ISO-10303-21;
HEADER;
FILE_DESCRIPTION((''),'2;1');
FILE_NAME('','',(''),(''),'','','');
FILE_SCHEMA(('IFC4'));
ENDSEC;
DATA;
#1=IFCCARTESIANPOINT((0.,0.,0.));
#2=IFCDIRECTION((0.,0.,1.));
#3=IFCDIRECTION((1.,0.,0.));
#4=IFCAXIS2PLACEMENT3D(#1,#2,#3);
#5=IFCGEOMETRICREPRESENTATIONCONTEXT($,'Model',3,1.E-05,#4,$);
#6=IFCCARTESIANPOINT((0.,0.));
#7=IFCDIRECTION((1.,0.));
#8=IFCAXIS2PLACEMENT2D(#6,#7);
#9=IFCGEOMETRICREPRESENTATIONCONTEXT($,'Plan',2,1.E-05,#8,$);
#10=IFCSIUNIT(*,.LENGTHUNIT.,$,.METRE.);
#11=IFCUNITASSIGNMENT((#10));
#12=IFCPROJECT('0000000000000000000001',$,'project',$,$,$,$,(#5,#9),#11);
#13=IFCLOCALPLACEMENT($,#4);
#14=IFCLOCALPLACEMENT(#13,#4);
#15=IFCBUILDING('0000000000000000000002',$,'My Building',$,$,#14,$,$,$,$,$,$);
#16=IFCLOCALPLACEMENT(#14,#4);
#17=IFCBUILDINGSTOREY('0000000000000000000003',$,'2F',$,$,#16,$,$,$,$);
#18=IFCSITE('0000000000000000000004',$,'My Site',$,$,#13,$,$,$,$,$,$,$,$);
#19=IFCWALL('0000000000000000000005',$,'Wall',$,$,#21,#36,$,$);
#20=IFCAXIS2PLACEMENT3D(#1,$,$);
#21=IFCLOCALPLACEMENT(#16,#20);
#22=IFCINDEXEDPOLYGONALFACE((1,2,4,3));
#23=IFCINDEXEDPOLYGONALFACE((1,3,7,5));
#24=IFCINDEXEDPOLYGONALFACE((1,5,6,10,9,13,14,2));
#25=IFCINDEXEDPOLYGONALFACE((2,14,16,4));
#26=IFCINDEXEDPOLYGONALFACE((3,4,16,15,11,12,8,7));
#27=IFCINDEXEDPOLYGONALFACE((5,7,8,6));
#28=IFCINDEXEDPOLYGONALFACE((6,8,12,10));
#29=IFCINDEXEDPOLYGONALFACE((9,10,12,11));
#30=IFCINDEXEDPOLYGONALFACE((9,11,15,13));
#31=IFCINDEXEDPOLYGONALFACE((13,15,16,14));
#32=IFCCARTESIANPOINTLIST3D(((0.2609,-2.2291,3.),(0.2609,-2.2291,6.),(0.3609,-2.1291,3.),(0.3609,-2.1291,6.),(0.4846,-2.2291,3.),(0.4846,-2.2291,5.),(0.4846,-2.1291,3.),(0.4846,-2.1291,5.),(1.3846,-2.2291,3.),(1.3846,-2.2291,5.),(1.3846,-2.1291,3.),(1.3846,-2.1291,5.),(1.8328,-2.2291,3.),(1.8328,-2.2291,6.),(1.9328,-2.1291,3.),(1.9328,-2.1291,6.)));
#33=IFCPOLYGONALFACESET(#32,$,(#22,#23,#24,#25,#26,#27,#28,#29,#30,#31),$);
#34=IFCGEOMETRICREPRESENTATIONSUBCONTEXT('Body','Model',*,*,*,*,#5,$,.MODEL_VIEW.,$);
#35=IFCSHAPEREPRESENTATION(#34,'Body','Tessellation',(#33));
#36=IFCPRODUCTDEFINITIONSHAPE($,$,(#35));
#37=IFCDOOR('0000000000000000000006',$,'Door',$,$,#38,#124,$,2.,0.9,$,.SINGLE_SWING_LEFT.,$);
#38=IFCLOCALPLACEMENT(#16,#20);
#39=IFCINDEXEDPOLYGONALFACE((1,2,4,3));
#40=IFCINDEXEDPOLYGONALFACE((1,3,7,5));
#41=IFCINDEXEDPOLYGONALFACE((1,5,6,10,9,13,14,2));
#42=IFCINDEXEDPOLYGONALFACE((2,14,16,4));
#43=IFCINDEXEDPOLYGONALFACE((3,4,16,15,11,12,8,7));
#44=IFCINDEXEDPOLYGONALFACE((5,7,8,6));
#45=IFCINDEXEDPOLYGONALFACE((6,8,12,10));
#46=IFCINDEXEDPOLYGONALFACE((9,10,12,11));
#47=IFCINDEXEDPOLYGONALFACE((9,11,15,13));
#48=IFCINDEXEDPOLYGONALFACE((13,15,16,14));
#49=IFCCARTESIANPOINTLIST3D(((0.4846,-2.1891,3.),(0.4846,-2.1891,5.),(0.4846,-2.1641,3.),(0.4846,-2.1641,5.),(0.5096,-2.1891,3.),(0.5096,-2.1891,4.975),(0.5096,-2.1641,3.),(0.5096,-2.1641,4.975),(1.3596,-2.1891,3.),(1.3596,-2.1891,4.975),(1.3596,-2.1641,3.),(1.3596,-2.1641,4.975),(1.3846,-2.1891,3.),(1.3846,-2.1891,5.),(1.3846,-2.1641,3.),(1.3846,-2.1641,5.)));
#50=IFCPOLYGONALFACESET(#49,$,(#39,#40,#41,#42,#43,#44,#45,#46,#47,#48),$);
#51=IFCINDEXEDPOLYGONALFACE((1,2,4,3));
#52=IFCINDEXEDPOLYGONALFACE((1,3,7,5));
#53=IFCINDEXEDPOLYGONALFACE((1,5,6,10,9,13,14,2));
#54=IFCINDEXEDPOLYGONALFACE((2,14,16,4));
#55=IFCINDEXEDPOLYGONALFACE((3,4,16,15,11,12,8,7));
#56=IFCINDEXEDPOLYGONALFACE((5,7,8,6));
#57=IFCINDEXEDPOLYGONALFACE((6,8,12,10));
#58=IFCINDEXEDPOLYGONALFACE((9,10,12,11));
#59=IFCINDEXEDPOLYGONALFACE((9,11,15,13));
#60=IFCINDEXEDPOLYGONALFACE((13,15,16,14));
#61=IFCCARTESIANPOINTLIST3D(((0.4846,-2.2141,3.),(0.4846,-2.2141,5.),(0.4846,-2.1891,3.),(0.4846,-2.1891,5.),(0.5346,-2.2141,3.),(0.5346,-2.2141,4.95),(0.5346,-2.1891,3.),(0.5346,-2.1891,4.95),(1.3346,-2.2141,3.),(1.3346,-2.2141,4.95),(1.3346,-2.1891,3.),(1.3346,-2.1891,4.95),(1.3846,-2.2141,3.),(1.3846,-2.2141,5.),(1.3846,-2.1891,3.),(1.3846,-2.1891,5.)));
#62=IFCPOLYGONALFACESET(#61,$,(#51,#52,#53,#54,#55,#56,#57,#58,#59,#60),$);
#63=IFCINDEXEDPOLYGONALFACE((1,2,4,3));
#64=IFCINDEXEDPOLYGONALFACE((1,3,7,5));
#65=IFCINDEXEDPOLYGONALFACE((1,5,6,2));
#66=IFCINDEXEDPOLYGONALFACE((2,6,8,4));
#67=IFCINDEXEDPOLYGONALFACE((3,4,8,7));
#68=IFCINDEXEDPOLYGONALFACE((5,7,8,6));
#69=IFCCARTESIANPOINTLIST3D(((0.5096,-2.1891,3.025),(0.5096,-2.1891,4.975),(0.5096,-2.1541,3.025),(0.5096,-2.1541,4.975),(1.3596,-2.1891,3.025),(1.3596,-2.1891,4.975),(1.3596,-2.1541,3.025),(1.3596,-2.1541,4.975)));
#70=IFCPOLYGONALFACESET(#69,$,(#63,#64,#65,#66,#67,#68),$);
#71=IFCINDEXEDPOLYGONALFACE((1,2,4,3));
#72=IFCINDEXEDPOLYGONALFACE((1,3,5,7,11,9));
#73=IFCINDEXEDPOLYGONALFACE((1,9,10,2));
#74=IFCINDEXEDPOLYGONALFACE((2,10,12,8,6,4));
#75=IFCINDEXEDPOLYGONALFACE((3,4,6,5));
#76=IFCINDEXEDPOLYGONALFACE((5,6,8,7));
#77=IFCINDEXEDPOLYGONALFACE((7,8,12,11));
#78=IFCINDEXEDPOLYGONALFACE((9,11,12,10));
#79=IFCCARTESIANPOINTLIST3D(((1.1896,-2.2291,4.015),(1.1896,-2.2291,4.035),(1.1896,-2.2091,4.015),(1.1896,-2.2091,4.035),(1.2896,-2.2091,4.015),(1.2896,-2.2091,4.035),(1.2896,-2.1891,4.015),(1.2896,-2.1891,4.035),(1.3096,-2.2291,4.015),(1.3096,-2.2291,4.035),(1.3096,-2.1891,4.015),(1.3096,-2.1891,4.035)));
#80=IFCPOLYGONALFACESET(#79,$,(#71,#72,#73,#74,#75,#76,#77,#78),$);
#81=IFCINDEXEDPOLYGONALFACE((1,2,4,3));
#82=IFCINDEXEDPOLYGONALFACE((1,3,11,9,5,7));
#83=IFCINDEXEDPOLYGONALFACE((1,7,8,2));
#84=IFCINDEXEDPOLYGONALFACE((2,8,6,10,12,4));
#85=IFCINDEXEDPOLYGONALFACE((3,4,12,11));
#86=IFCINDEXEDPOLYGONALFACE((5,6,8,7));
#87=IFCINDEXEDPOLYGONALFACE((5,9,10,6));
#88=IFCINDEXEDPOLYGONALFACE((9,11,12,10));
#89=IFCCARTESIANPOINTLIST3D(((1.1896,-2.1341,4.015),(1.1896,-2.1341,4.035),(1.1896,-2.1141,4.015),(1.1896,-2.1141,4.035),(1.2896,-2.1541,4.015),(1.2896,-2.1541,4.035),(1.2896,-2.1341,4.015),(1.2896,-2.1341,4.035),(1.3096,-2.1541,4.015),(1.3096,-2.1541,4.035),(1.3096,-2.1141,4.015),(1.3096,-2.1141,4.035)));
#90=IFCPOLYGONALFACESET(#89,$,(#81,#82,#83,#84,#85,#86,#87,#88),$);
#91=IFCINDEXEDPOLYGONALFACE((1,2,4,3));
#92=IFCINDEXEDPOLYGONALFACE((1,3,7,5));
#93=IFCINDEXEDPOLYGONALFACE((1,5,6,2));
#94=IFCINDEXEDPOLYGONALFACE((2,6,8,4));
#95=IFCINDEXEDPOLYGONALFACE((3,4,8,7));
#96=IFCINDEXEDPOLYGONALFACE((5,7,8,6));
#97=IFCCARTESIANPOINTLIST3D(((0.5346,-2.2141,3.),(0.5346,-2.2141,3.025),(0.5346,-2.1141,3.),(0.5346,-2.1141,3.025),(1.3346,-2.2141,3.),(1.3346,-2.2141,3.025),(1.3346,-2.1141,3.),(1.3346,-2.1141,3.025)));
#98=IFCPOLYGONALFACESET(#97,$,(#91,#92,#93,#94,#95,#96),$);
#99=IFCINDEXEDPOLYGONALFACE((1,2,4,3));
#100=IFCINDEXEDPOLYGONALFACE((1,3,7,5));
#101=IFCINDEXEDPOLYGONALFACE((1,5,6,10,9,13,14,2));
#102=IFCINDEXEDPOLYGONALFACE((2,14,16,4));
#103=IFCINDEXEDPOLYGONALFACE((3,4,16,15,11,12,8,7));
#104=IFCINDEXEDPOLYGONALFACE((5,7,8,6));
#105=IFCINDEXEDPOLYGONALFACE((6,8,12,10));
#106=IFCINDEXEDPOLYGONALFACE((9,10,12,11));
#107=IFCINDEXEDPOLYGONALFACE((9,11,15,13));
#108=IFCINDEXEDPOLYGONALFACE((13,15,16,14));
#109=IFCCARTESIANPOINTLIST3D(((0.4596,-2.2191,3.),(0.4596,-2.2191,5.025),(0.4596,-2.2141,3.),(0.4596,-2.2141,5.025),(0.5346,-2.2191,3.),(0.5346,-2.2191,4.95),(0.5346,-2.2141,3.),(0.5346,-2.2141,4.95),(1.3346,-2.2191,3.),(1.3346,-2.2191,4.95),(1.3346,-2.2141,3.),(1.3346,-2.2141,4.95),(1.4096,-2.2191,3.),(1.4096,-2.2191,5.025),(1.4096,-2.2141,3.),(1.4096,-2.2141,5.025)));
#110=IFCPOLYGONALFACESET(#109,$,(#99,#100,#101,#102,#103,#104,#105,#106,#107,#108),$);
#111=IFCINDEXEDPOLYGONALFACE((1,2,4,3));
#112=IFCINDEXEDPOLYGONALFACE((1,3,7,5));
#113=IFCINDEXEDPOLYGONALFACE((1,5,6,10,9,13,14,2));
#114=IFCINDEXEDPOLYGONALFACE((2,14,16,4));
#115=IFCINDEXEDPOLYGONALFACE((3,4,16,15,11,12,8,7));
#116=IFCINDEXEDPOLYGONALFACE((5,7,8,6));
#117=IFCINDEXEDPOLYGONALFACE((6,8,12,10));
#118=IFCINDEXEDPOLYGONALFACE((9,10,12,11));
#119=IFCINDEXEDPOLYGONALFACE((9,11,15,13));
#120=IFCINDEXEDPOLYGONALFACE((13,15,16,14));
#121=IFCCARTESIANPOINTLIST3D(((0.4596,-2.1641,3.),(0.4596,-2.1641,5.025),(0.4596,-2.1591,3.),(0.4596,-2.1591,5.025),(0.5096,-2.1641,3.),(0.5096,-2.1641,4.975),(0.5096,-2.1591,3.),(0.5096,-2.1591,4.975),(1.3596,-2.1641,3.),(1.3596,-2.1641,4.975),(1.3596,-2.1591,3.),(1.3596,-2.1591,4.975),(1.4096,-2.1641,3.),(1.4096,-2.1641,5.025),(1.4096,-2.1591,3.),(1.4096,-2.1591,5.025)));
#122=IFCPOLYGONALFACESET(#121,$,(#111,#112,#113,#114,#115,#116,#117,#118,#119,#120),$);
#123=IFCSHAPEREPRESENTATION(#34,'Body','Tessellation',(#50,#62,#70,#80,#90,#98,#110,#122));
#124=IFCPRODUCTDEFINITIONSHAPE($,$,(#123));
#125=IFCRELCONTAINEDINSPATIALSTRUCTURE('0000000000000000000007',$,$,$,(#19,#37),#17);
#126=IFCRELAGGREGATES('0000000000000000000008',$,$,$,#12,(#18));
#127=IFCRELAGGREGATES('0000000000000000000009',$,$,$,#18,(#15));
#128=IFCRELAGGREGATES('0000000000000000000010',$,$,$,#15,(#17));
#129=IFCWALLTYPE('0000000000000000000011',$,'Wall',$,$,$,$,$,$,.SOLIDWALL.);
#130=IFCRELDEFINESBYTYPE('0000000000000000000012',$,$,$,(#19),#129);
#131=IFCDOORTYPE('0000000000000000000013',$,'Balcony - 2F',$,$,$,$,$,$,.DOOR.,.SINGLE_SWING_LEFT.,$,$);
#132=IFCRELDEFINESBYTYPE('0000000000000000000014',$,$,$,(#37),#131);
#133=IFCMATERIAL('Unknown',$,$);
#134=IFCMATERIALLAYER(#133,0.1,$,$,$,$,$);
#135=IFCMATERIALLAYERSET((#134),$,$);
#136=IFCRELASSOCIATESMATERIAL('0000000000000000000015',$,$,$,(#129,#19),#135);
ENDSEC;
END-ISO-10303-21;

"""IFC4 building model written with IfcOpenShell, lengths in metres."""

from ifc_helpers import new_model, entity, si_unit, frame, origin_with_axes, origin_2d_with_axis, place, context, subcontext, project, spatial, line, indexed_curve, outline, extrude, shape, source, transform, mapped, material, layer, layer_set, layer_usage, type_object, type_shapes, element, fill, save


model = new_model("IFC4")

# Units and contexts
model_context = context("Model", 3, precision=1e-05, world=origin_with_axes())
plan_context = context("Plan", 2, precision=1e-05, world=origin_2d_with_axis())
body_context_1 = subcontext(model_context, "Body", "Model", "MODEL_VIEW")
body_context_2 = subcontext(plan_context, "Body", "Plan", "PLAN_VIEW")
ifc_project = project(units=[si_unit("LENGTHUNIT", "METRE")], contexts=[model_context, plan_context])

# Site, building, storey
site_placement = place(None, origin_with_axes())
site = spatial("IfcSite", under=ifc_project, at=site_placement, Name="My Site")
building_placement = place(site_placement, origin_with_axes())
building = spatial("IfcBuilding", under=site, at=building_placement, Name="My Building")
storey_placement = place(building_placement, origin_with_axes())
storey = spatial("IfcBuildingStorey", under=building, at=storey_placement, Name="2F")

# Shared definitions
ifc_material = material(Name="Unknown")
ifc_layer = layer(ifc_material, 0.1)
ifc_layer_set = layer_set([ifc_layer])
wall_type = type_object("IfcWallType", Name="Wall", PredefinedType="SOLIDWALL", material=ifc_layer_set)

# Wall, opening, door
ifc_layer_usage_1 = layer_usage(ifc_layer_set, "AXIS2", "POSITIVE", 0.0)
wall_1_placement = place(storey_placement, frame((0.2609, -2.2291, 3.0), z_axis=(0.0, 0.0, 1.0), x_axis=(1.0, 0.0, 0.0)))
wall_1 = element("IfcWall", 1, at=wall_1_placement, inside=storey, type_object=wall_type, material=ifc_layer_usage_1, Name="Wall", context=body_context_1, shape_type="SweptSolid", body=[
    extrude(outline(indexed_curve([(0.0, 0.0), (0.1, 0.1), (1.6718, 0.1), (1.5718, 0.0)], segments=[line(1, 2, 3, 4, 1)])), origin_with_axes(), (0.0, 0.0, 1.0), 3.0),
])
shared_shape_1 = source(origin_with_axes(), body_context_1, "Body", "SweptSolid", [
    extrude(outline(indexed_curve([(0.0, 0.0), (0.9, 0.0), (0.9, 2.0), (0.0, 2.0)], segments=[line(1, 2, 3, 4, 1)])), frame((0.0, -0.6, 0.0), z_axis=(0.0, -1.0, 0.0), x_axis=(1.0, 0.0, 0.0)), (0.0, 0.0, -1.0), 1.2),
])
opening_1_placement = place(wall_1_placement, frame((0.2236, 0.015, 0.0), z_axis=(0.0, 0.0, 1.0), x_axis=(1.0, 0.0, 0.0)))
opening_1 = element("IfcOpeningElement", 2, at=opening_1_placement, cuts=wall_1, PredefinedType="OPENING", context=body_context_1, shape_type="MappedRepresentation", body=[
    mapped(shared_shape_1, transform((0.0, 0.0, 0.0), x_axis=(1.0, 0.0, 0.0), y_axis=(0.0, 1.0, 0.0), z_axis=(0.0, 0.0, 1.0), scale=1.0)),
])
door_type_1 = type_object("IfcDoorType", Name="Balcony - 2F", OperationType="SINGLE_SWING_LEFT", PredefinedType="DOOR")
shared_shape_2 = source(origin_with_axes(), body_context_1, "Body", "SweptSolid", [
    extrude(outline(indexed_curve([(0.0, 0.0), (0.0, 2.0), (0.9, 2.0), (0.9, 0.0), (0.875, 0.0), (0.875, 1.975), (0.025, 1.975), (0.025, 0.0)], segments=[line(1, 2, 3, 4, 5, 6, 7, 8, 1)])), frame((0.0, 0.025, 0.0), z_axis=(0.0, -1.0, 0.0), x_axis=(1.0, 0.0, 0.0)), (0.0, 0.0, -1.0), 0.025),
    extrude(outline(indexed_curve([(0.0, 0.0), (0.0, 2.0), (0.9, 2.0), (0.9, 0.0), (0.85, 0.0), (0.85, 1.95), (0.05, 1.95), (0.05, 0.0)], segments=[line(1, 2, 3, 4, 5, 6, 7, 8, 1)])), frame((0.0, 0.0, 0.0), z_axis=(0.0, -1.0, 0.0), x_axis=(1.0, 0.0, 0.0)), (0.0, 0.0, -1.0), 0.025),
    extrude(outline(indexed_curve([(0.0, 0.0), (0.85, 0.0), (0.85, 0.035), (0.0, 0.035)], segments=[line(1, 2, 3, 4, 1)])), frame((0.025, 0.025, 0.025), z_axis=(0.0, 0.0, 1.0), x_axis=(1.0, 0.0, 0.0)), (0.0, 0.0, 1.0), 1.95),
    extrude(outline(indexed_curve([(0.0, 0.0), (0.0, -0.04), (-0.12, -0.04), (-0.12, -0.02), (-0.02, -0.02), (-0.02, 0.0)], segments=[line(1, 2, 3, 4, 5, 6, 1)])), frame((0.825, 0.025, 1.015), z_axis=(0.0, 0.0, 1.0), x_axis=(1.0, 0.0, 0.0)), (0.0, 0.0, 1.0), 0.02),
    extrude(outline(indexed_curve([(0.0, 0.0), (0.0, 0.04), (-0.12, 0.04), (-0.12, 0.02), (-0.02, 0.02), (-0.02, 0.0)], segments=[line(1, 2, 3, 4, 5, 6, 1)])), frame((0.825, 0.06, 1.015), z_axis=(0.0, 0.0, 1.0), x_axis=(1.0, 0.0, 0.0)), (0.0, 0.0, 1.0), 0.02),
    extrude(outline(indexed_curve([(0.0, 0.0), (0.8, 0.0), (0.8, 0.1), (0.0, 0.1)], segments=[line(1, 2, 3, 4, 1)])), frame((0.05, 0.0, 0.0), z_axis=(0.0, 0.0, 1.0), x_axis=(1.0, 0.0, 0.0)), (0.0, 0.0, 1.0), 0.025),
    extrude(outline(indexed_curve([(0.0, 0.0), (0.0, 2.025), (0.95, 2.025), (0.95, 0.0), (0.875, 0.0), (0.875, 1.95), (0.075, 1.95), (0.075, 0.0)], segments=[line(1, 2, 3, 4, 5, 6, 7, 8, 1)])), frame((-0.025, -0.005, 0.0), z_axis=(0.0, -1.0, 0.0), x_axis=(1.0, 0.0, 0.0)), (0.0, 0.0, -1.0), 0.005),
    extrude(outline(indexed_curve([(0.0, 0.0), (0.0, 2.025), (0.95, 2.025), (0.95, 0.0), (0.9, 0.0), (0.9, 1.975), (0.05, 1.975), (0.05, 0.0)], segments=[line(1, 2, 3, 4, 5, 6, 7, 8, 1)])), frame((-0.025, 0.05, 0.0), z_axis=(0.0, -1.0, 0.0), x_axis=(1.0, 0.0, 0.0)), (0.0, 0.0, -1.0), 0.005),
])
shared_shape_3 = source(origin_with_axes(), body_context_2, "Body", "Curve2D", [
    entity("IfcIndexedPolyCurve", entity("IfcCartesianPointList2D", [[0.0, 0.0], [0.0, 0.05], [0.025, 0.05], [0.025, 0.025], [0.05, 0.025], [0.05, 0.0]]), [entity("IfcLineIndex", [1, 2, 3, 4, 5, 6, 1])]),
    entity("IfcIndexedPolyCurve", entity("IfcCartesianPointList2D", [[0.9, 0.0], [0.9, 0.05], [0.875, 0.05], [0.875, 0.025], [0.85, 0.025], [0.85, 0.0]]), [entity("IfcLineIndex", [1, 2, 3, 4, 5, 6, 1])]),
    entity("IfcTrimmedCurve", entity("IfcEllipse", entity("IfcAxis2Placement2D", entity("IfcCartesianPoint", [0.06, 0.05]), entity("IfcDirection", [1.0, 0.0])), 0.815, 0.85), [entity("IfcCartesianPoint", [0.875, 0.05])], [entity("IfcCartesianPoint", [0.06, 0.9])], True, "CARTESIAN"),
    entity("IfcIndexedPolyCurve", entity("IfcCartesianPointList2D", [[0.025, 0.05], [0.06, 0.05], [0.06, 0.9], [0.025, 0.9]]), [entity("IfcLineIndex", [1, 2, 3, 4, 1])]),
])
type_shapes(door_type_1, [shared_shape_2, shared_shape_3])
door_1_placement = place(opening_1_placement, frame((0.0, 0.0, 0.0), z_axis=(0.0, 0.0, 1.0), x_axis=(1.0, 0.0, 0.0)))
door_1 = element("IfcDoor", 3, at=door_1_placement, inside=storey, type_object=door_type_1, Name="Door", OperationType="SINGLE_SWING_LEFT", OverallHeight=2.0, OverallWidth=0.9, shapes=[
    shape(body_context_1, "Body", "MappedRepresentation", [mapped(shared_shape_2, transform((0.0, 0.0, 0.0), x_axis=(1.0, 0.0, 0.0), y_axis=(0.0, 1.0, 0.0), z_axis=(0.0, 0.0, 1.0), scale=1.0))]),
    shape(body_context_2, "Body", "MappedRepresentation", [mapped(shared_shape_3, transform((0.0, 0.0, 0.0), x_axis=(1.0, 0.0, 0.0), y_axis=(0.0, 1.0, 0.0), z_axis=(0.0, 0.0, 1.0), scale=1.0))]),
])
fill(opening_1, door_1)

save(model, "model.ifc")
